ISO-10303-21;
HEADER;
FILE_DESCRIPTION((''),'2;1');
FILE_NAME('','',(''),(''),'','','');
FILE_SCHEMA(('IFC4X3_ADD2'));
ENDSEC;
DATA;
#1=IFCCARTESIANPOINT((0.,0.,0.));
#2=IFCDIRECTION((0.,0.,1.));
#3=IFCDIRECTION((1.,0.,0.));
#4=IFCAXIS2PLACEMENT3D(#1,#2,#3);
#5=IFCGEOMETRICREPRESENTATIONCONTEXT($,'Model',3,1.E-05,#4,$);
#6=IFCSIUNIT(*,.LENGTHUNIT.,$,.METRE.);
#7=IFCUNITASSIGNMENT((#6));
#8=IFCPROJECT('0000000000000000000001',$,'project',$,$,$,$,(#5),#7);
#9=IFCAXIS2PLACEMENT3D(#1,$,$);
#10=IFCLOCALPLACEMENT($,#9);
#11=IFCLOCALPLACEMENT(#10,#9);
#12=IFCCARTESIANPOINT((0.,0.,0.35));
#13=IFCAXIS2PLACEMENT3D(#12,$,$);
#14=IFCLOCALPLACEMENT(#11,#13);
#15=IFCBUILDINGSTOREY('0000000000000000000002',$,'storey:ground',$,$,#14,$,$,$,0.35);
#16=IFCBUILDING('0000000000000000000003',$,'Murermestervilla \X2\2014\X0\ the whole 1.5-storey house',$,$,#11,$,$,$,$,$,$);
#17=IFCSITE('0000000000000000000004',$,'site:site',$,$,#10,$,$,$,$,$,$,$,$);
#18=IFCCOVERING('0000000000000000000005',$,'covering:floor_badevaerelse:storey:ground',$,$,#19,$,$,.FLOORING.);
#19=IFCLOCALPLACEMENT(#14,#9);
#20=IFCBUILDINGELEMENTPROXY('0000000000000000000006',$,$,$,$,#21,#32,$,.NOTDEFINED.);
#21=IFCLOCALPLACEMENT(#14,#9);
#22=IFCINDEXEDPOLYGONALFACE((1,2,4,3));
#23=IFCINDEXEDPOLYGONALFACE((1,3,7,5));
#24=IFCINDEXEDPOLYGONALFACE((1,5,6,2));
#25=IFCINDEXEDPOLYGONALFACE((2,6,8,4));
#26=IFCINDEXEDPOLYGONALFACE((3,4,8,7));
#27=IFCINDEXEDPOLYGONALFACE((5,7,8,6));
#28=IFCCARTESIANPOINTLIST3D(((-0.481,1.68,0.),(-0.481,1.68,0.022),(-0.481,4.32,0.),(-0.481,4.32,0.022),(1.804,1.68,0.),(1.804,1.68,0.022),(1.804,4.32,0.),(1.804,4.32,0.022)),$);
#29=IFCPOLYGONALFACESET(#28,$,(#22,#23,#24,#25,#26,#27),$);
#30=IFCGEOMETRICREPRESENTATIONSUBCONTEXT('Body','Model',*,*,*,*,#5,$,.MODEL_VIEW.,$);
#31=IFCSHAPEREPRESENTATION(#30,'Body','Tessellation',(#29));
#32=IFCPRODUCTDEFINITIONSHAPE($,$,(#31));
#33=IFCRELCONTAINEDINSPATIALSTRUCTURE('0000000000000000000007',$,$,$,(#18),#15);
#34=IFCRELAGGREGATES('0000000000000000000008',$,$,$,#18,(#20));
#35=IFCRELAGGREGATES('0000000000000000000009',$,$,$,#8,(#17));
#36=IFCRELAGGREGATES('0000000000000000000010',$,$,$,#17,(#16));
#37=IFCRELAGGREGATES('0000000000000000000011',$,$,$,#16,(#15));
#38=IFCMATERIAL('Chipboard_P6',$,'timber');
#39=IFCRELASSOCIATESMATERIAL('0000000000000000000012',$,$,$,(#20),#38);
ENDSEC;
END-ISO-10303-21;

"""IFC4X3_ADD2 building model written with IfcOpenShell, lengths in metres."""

from ifc_helpers import new_model, si_unit, frame, origin, origin_with_axes, place, context, subcontext, project, spatial, rectangle, extrude, material, element, aggregate, save


model = new_model("IFC4X3_ADD2")

# Units and contexts
model_context = context("Model", 3, precision=1e-05, world=origin_with_axes())
body_context = subcontext(model_context, "Body", "Model", "MODEL_VIEW")
ifc_project = project(units=[si_unit("LENGTHUNIT", "METRE")], contexts=[model_context])

# Site, building, storey
site_placement = place(None, origin())
site = spatial("IfcSite", under=ifc_project, at=site_placement, Name="site:site")
building_placement = place(site_placement, origin())
building = spatial("IfcBuilding", under=site, at=building_placement, Name="Murermestervilla — the whole 1.5-storey house")
storey_placement = place(building_placement, frame((0.0, 0.0, 0.35)))
storey = spatial("IfcBuildingStorey", under=building, at=storey_placement, Name="storey:ground", Elevation=0.35)

# Covering, building element proxy
covering_placement = place(storey_placement, frame((0.0, 0.0, -0.35)))
covering = element("IfcCovering", 1, at=covering_placement, inside=storey, Name="covering:floor_badevaerelse:storey:ground", PredefinedType="FLOORING")
ifc_material_1 = material(Name="Chipboard_P6", Category="timber")
proxy_1_placement = place(None, frame((0.6615, 3.0, 0.361)))
proxy_1 = element("IfcBuildingElementProxy", 2, at=proxy_1_placement, material=ifc_material_1, PredefinedType="NOTDEFINED", context=body_context, shape_type="SweptSolid", body=[
    extrude(rectangle(XDim=2.285, YDim=2.64), frame((0.0, 0.0, -0.011)), (0.0, 0.0, 1.0), 0.022),
])
aggregate(covering, [proxy_1])

save(model, "model.ifc")
